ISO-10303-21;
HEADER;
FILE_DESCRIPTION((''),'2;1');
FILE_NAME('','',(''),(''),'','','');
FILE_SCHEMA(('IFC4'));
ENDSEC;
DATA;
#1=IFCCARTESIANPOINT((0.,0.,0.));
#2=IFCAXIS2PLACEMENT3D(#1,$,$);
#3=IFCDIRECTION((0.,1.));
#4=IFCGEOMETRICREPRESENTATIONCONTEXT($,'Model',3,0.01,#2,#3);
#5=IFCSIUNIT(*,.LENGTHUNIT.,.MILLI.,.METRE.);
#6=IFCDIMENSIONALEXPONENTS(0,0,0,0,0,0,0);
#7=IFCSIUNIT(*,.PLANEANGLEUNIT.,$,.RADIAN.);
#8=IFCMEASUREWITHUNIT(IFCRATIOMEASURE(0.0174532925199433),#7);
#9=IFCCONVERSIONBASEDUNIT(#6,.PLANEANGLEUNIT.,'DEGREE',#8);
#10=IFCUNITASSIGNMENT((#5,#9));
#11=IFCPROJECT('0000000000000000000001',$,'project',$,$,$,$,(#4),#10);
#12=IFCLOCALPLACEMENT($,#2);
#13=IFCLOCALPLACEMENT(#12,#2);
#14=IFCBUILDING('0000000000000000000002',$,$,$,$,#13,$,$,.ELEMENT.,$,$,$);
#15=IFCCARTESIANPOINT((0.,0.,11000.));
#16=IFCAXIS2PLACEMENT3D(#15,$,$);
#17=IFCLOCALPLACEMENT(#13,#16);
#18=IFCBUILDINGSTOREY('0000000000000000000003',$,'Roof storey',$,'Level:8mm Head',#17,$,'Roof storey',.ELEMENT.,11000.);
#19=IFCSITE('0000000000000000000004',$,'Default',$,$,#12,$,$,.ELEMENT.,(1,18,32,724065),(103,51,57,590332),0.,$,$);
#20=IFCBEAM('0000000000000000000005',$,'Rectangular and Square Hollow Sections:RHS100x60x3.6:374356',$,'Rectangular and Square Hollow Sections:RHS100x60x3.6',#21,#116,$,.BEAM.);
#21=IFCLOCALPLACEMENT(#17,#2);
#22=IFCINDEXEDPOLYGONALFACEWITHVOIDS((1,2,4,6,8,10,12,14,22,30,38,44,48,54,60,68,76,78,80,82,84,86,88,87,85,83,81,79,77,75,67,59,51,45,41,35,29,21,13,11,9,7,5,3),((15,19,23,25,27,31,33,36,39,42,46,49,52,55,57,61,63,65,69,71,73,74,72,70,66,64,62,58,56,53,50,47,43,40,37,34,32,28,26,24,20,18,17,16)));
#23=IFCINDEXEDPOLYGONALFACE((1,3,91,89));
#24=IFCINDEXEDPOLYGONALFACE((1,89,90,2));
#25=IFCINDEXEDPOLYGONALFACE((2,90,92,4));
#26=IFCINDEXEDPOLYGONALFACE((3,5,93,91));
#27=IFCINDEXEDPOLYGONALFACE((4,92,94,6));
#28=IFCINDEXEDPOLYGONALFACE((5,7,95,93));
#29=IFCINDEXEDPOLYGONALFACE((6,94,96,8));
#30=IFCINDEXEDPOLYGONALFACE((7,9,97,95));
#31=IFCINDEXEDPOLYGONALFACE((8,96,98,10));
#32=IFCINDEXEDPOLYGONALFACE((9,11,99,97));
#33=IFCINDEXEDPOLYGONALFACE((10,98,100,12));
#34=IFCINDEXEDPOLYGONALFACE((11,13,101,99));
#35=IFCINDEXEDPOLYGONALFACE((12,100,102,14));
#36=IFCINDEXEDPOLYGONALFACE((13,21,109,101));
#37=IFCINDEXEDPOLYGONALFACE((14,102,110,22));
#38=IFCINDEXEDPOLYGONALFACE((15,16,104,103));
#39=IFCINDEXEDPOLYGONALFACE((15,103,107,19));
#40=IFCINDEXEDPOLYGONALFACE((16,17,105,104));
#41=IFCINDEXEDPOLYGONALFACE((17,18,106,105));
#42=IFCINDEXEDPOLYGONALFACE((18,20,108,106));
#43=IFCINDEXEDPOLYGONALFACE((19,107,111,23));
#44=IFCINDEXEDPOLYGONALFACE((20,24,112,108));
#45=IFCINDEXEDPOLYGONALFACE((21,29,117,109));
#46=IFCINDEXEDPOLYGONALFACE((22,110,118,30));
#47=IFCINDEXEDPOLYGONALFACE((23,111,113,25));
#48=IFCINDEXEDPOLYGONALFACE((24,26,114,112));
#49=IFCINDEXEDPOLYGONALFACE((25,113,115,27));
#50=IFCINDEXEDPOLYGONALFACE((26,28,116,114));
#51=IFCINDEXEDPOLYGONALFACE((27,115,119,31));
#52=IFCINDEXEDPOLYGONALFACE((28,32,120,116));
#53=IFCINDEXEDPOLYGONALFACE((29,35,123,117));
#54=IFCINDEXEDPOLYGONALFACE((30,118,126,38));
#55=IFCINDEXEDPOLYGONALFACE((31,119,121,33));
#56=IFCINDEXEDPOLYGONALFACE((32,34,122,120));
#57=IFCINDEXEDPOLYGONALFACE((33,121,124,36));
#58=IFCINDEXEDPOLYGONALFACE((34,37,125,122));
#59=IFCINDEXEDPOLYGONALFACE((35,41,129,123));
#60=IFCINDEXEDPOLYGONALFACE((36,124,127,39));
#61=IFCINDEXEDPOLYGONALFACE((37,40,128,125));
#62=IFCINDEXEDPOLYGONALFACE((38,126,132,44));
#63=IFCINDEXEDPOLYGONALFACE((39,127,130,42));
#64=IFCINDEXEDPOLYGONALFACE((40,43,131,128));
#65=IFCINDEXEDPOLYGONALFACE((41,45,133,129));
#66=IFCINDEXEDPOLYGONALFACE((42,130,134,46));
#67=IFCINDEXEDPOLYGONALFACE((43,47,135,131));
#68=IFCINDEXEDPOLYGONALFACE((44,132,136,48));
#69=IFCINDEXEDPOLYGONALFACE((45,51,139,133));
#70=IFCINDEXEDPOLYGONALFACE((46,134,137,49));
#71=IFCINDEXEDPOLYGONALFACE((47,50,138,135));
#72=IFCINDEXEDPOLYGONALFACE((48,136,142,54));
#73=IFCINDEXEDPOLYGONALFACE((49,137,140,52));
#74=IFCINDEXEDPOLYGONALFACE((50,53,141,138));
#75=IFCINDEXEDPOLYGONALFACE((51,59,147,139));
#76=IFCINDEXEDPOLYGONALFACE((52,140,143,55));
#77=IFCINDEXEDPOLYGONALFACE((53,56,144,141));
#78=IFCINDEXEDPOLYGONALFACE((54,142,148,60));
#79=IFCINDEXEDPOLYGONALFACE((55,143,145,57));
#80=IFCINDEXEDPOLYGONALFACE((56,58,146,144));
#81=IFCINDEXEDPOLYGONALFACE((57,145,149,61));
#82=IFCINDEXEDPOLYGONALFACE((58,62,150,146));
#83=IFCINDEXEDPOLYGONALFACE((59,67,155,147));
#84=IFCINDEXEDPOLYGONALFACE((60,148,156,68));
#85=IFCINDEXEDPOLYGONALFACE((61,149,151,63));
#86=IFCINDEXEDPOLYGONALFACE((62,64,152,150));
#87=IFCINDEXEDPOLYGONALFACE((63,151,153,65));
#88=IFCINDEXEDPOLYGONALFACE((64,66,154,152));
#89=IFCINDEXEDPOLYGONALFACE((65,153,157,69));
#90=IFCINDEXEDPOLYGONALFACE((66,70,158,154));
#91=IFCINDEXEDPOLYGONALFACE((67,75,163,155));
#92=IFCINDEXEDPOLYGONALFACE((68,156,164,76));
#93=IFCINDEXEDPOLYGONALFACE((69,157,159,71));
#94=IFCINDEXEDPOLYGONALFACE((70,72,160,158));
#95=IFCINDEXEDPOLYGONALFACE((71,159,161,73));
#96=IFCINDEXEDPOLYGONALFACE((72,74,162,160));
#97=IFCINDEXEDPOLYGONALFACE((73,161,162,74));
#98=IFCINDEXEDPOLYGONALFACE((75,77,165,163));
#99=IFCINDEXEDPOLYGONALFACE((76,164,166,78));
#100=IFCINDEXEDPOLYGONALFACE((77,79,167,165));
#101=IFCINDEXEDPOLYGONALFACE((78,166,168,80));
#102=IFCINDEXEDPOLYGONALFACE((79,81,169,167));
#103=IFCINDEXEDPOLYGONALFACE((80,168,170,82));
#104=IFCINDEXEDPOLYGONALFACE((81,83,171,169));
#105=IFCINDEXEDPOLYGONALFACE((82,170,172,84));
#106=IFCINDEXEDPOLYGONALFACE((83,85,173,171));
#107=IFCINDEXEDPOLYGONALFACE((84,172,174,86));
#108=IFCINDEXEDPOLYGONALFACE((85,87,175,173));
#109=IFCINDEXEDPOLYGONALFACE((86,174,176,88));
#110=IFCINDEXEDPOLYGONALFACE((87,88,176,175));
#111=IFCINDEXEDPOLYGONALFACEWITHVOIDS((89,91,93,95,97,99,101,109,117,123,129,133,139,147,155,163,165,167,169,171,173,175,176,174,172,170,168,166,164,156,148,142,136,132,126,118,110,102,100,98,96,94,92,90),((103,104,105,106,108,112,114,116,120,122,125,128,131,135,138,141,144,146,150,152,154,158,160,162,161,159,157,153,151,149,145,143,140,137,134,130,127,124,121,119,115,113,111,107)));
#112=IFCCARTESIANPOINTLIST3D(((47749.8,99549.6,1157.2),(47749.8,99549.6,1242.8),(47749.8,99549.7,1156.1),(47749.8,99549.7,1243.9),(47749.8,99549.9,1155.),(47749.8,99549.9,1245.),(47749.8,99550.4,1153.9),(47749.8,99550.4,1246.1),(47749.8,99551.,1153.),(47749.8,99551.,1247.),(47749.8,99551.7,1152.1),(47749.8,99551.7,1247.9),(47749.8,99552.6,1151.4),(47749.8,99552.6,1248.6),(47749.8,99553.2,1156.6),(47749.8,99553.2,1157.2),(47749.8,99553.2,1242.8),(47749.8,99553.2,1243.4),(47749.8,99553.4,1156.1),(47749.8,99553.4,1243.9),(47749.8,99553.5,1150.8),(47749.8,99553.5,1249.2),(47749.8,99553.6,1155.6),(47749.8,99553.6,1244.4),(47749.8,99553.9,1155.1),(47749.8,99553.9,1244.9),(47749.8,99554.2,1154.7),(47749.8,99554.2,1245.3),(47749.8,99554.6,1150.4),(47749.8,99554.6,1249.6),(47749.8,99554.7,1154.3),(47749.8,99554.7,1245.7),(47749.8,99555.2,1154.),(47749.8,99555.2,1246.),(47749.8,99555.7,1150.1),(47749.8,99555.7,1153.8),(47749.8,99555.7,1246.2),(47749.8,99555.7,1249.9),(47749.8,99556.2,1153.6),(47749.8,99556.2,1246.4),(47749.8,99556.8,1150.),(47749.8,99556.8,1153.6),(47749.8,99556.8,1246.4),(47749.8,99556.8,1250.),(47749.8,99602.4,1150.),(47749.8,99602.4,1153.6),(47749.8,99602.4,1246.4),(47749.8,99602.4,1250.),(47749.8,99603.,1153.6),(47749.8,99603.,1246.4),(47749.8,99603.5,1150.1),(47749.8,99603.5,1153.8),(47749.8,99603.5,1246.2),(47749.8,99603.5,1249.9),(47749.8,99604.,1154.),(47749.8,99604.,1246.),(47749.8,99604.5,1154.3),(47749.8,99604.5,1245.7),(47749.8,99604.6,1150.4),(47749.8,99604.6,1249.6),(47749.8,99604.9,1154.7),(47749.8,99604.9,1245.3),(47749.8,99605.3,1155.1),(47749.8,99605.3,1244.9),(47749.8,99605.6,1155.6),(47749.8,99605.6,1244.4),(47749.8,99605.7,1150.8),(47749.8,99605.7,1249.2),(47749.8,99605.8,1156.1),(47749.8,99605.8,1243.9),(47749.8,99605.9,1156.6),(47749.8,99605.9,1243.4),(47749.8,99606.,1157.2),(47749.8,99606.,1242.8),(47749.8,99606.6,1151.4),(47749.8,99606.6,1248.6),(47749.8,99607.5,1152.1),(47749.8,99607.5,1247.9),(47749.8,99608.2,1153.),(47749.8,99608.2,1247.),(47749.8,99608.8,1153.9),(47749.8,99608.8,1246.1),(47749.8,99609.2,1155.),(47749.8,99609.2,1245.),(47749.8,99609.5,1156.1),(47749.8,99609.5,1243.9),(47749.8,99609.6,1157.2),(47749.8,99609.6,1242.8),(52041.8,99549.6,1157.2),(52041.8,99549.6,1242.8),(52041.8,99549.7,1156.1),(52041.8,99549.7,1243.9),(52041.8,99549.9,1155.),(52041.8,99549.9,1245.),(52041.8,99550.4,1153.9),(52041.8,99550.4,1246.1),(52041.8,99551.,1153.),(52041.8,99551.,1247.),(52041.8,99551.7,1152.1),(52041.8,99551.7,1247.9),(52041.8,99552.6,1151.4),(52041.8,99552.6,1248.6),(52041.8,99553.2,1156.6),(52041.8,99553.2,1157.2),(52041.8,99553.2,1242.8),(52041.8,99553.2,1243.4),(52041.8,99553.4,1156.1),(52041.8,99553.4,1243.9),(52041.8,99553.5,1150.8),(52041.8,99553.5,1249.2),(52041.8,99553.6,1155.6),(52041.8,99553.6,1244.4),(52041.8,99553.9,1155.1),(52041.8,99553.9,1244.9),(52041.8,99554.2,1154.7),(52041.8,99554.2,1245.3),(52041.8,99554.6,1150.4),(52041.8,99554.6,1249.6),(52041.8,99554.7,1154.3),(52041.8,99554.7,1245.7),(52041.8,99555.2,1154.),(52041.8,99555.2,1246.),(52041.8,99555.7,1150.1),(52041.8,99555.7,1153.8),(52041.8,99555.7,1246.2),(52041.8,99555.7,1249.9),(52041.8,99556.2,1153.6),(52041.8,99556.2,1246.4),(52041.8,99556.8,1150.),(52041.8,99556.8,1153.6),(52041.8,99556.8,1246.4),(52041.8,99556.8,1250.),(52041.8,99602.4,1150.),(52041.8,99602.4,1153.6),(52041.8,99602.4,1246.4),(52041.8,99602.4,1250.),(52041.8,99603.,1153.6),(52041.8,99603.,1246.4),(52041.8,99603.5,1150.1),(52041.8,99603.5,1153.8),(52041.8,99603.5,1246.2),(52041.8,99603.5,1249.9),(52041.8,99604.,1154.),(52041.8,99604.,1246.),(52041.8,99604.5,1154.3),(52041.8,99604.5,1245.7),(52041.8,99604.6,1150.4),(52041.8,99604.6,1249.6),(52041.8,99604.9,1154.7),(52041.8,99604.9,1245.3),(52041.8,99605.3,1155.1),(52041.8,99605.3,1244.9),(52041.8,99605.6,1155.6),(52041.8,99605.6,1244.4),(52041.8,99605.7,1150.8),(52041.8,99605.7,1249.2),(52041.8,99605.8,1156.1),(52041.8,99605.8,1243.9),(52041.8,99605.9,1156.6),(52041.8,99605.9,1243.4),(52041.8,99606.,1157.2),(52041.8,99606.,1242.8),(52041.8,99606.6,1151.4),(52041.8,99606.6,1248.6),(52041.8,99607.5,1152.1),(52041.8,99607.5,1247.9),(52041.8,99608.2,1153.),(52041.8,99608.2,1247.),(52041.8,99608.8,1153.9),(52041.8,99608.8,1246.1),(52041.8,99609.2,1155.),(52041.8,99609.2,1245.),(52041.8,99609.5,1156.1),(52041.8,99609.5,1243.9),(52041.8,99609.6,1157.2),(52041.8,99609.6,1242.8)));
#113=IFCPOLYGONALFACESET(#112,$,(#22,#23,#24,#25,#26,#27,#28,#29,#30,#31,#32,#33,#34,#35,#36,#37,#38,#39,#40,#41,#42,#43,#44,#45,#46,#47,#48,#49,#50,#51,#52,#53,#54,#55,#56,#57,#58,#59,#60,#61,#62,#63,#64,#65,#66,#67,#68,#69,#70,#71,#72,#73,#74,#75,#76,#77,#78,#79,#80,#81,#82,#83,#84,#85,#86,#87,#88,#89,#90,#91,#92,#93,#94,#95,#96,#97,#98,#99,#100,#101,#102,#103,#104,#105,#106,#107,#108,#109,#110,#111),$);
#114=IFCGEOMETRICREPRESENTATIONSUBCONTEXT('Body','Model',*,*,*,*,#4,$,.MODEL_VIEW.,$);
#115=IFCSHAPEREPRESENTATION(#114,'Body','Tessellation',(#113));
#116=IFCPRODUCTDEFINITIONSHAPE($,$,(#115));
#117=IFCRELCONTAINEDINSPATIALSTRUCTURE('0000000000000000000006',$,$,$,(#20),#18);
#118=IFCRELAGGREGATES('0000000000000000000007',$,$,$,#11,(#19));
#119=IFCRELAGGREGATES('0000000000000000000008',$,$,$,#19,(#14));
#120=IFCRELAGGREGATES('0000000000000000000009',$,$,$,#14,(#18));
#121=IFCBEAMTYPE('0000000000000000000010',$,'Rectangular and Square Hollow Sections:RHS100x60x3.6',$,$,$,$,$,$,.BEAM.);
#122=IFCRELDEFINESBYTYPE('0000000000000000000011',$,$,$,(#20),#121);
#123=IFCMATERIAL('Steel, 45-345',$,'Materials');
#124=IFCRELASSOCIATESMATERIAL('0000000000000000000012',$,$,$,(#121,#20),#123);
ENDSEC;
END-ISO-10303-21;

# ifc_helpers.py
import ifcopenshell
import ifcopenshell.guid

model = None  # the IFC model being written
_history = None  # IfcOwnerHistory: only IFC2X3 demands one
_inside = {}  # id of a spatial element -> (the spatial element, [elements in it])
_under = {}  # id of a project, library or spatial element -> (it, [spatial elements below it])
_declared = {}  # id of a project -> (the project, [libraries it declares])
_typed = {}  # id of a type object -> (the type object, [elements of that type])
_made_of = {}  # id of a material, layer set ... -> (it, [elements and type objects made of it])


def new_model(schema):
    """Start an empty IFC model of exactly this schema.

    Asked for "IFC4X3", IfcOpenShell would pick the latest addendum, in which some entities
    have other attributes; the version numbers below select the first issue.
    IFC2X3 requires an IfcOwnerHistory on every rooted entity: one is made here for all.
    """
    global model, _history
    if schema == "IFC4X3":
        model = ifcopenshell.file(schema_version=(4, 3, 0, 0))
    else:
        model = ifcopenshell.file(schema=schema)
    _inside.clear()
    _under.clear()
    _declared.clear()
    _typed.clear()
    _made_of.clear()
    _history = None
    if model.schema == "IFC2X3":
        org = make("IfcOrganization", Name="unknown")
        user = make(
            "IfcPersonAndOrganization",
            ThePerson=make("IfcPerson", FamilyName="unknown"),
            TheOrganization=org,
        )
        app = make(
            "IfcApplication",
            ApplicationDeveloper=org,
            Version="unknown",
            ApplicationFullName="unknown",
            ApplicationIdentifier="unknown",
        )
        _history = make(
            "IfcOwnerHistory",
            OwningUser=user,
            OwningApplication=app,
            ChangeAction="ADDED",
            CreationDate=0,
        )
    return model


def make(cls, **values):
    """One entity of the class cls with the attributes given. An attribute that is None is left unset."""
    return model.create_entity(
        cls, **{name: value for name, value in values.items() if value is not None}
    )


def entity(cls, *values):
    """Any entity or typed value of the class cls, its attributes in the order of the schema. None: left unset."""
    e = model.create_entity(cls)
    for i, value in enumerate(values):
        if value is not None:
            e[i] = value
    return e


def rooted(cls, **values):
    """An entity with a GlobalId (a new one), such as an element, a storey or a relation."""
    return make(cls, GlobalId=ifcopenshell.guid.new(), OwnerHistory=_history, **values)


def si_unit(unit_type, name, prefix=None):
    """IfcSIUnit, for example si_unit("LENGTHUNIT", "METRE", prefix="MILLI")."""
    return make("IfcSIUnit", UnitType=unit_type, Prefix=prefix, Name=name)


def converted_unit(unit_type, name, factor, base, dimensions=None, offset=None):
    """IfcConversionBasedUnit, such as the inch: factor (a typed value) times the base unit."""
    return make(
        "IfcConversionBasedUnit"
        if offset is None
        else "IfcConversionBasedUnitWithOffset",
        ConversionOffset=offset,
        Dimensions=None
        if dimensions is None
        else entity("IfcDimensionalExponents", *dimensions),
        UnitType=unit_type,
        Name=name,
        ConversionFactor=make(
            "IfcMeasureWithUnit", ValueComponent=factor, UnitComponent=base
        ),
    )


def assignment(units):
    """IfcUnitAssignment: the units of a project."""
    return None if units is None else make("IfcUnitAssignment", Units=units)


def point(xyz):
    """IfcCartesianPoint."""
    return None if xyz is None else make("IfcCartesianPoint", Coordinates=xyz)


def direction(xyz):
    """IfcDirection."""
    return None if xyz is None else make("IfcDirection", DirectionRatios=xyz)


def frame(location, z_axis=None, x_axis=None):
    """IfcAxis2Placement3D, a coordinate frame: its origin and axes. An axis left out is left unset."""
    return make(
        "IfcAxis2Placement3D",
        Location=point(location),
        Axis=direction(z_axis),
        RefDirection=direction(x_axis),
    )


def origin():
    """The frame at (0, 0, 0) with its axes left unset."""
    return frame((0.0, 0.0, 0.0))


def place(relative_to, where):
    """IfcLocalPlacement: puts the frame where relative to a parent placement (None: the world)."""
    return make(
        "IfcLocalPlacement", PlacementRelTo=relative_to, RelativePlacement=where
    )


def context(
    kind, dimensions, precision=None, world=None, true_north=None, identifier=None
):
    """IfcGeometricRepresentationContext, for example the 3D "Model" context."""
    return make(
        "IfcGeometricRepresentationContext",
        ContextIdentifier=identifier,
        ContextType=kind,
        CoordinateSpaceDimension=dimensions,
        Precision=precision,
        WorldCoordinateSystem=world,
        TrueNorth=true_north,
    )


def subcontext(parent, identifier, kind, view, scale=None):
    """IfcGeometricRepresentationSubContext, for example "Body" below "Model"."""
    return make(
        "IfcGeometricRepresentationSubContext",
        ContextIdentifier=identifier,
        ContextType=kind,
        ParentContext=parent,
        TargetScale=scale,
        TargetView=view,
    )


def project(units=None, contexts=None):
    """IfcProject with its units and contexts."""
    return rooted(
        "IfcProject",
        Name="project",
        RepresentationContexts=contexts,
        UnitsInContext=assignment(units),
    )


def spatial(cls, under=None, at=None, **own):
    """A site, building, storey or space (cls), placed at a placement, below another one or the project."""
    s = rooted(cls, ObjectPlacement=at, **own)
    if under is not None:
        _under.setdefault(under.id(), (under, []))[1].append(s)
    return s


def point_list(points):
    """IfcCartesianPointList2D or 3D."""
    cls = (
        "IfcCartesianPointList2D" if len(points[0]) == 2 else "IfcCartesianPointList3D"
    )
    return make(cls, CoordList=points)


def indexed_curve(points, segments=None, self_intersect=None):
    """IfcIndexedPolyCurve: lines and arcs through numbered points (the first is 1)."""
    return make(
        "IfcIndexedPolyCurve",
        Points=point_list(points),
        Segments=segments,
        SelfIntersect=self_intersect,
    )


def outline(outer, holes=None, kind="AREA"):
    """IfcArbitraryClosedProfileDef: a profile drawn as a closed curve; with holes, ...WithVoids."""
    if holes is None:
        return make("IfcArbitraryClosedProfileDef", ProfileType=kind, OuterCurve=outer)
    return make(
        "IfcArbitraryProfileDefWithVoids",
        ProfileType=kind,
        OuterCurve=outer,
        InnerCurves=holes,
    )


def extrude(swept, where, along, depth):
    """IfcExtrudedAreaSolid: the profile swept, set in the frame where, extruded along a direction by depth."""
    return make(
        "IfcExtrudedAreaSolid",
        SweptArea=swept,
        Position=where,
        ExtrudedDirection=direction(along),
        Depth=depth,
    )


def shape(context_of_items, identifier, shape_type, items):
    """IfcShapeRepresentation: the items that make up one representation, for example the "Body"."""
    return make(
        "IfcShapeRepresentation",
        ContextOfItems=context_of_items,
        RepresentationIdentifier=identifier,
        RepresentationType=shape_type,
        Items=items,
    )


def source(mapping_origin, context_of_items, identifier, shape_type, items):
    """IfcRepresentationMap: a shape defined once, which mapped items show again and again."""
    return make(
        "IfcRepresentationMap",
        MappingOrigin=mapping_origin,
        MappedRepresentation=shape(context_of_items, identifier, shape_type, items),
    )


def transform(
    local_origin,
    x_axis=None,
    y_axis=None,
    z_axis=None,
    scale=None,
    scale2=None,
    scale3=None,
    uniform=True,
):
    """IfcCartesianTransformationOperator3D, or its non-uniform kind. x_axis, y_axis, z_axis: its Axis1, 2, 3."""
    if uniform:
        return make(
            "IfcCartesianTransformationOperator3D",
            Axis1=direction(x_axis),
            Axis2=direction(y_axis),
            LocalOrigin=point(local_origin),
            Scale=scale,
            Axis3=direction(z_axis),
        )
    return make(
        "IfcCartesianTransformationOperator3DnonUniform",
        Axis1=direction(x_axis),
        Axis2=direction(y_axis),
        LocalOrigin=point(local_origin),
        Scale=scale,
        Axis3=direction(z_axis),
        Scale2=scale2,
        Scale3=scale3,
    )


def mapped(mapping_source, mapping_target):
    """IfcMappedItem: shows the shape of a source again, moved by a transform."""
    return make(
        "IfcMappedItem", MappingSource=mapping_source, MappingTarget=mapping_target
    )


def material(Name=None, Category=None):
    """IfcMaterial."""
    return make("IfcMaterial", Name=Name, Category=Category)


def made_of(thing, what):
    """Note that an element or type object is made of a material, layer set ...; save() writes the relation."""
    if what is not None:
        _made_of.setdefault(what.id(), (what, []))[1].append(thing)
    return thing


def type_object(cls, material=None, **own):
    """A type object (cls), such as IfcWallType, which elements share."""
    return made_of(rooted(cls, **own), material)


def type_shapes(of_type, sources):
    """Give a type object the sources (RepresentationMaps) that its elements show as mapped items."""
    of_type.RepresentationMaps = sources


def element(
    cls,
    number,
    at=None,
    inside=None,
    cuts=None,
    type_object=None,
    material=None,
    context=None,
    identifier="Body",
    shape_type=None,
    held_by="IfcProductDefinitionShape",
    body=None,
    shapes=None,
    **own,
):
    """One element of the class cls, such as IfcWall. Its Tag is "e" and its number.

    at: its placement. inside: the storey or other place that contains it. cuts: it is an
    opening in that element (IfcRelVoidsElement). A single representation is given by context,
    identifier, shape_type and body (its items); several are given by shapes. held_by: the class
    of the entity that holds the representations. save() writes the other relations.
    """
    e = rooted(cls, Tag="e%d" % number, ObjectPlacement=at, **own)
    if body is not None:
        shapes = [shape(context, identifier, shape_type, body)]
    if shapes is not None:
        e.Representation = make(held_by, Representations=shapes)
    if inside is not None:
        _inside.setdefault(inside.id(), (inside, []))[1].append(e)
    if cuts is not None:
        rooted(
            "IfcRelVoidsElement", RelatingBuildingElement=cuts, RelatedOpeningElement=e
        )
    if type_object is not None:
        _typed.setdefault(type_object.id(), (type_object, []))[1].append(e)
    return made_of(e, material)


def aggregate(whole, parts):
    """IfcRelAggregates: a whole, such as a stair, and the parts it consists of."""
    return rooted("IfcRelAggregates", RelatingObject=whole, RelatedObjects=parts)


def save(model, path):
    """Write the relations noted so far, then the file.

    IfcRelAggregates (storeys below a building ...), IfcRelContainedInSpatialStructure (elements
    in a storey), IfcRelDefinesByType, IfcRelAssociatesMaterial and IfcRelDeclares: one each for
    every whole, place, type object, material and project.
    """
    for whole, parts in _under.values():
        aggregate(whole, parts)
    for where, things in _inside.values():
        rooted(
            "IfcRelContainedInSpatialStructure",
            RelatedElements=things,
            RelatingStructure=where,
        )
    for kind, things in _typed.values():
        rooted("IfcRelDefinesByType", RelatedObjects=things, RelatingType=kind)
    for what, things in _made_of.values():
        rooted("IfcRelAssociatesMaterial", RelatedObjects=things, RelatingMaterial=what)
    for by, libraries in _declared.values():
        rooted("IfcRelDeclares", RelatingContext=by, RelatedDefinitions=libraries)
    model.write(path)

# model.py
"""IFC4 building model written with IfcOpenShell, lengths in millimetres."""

from ifc_helpers import new_model, entity, si_unit, converted_unit, direction, frame, origin, place, context, subcontext, project, spatial, indexed_curve, outline, extrude, source, transform, mapped, material, type_object, type_shapes, element, save


model = new_model("IFC4")

# Units and contexts
model_context = context("Model", 3, precision=0.01, world=origin(), true_north=direction((0.0, 1.0)))
body_context = subcontext(model_context, "Body", "Model", "MODEL_VIEW")
ifc_project = project(units=[si_unit("LENGTHUNIT", "METRE", prefix="MILLI"), converted_unit("PLANEANGLEUNIT", "DEGREE", entity("IfcRatioMeasure", 0.0174532925199433), si_unit("PLANEANGLEUNIT", "RADIAN"), dimensions=[0, 0, 0, 0, 0, 0, 0])], contexts=[model_context])

# Site, building, storey
site_placement = place(None, origin())
site = spatial("IfcSite", under=ifc_project, at=site_placement, Name="Default", CompositionType="ELEMENT", RefLatitude=(1, 18, 32, 724065), RefLongitude=(103, 51, 57, 590332), RefElevation=0.0)
building_placement = place(site_placement, origin())
building = spatial("IfcBuilding", under=site, at=building_placement, CompositionType="ELEMENT")
storey_placement = place(building_placement, frame((0.0, 0.0, 11000.0)))
storey = spatial("IfcBuildingStorey", under=building, at=storey_placement, Name="Roof storey", ObjectType="Level:8mm Head", LongName="Roof storey", CompositionType="ELEMENT", Elevation=11000.0)

# Shared definitions
ifc_material = material(Name="Steel, 45-345", Category="Materials")

# Beam
beam_type_1 = type_object("IfcBeamType", Name="Rectangular and Square Hollow Sections:RHS100x60x3.6", PredefinedType="BEAM", material=ifc_material)
shared_shape_1 = source(origin(), body_context, "Body", "SweptSolid", [
    extrude(outline(indexed_curve([(-30.0, -42.8), (-29.9, -43.9), (-29.6, -45.0), (-29.2, -46.1), (-28.6, -47.0), (-27.9, -47.9), (-27.0, -48.6), (-26.1, -49.2), (-25.0, -49.6), (-23.9, -49.9), (-22.8, -50.0), (22.8, -50.0), (23.9, -49.9), (25.0, -49.6), (26.1, -49.2), (27.0, -48.6), (27.9, -47.9), (28.6, -47.0), (29.2, -46.1), (29.6, -45.0), (29.9, -43.9), (30.0, -42.8), (30.0, 42.8), (29.9, 43.9), (29.6, 45.0), (29.2, 46.1), (28.6, 47.0), (27.9, 47.9), (27.0, 48.6), (26.1, 49.2), (25.0, 49.6), (23.9, 49.9), (22.8, 50.0), (-22.8, 50.0), (-23.9, 49.9), (-25.0, 49.6), (-26.1, 49.2), (-27.0, 48.6), (-27.9, 47.9), (-28.6, 47.0), (-29.2, 46.1), (-29.6, 45.0), (-29.9, 43.9), (-30.0, 42.8), (-30.0, -42.8)], self_intersect=False), holes=[indexed_curve([(22.8, -46.4), (-22.8, -46.4), (-23.4, -46.4), (-23.9, -46.2), (-24.4, -46.0), (-24.9, -45.7), (-25.3, -45.3), (-25.7, -44.9), (-26.0, -44.4), (-26.2, -43.9), (-26.4, -43.4), (-26.4, -42.8), (-26.4, 42.8), (-26.4, 43.4), (-26.2, 43.9), (-26.0, 44.4), (-25.7, 44.9), (-25.3, 45.3), (-24.9, 45.7), (-24.4, 46.0), (-23.9, 46.2), (-23.4, 46.4), (-22.8, 46.4), (22.8, 46.4), (23.4, 46.4), (23.9, 46.2), (24.4, 46.0), (24.9, 45.7), (25.3, 45.3), (25.7, 44.9), (26.0, 44.4), (26.2, 43.9), (26.4, 43.4), (26.4, 42.8), (26.4, -42.8), (26.4, -43.4), (26.2, -43.9), (26.0, -44.4), (25.7, -44.9), (25.3, -45.3), (24.9, -45.7), (24.4, -46.0), (23.9, -46.2), (23.4, -46.4), (22.8, -46.4)], self_intersect=False)]), frame((-2139.5, 0.0, 0.0), z_axis=(1.0, 0.0, 0.0), x_axis=(0.0, -1.0, 0.0)), (0.0, 0.0, 1.0), 4292.0),
])
type_shapes(beam_type_1, [shared_shape_1])
for number, where, name in (
    (1, (49889.3, 99579.6, 1200.0), "Rectangular and Square Hollow Sections:RHS100x60x3.6:374356"),
):
    element("IfcBeam", number, at=place(storey_placement, frame(where)), inside=storey, type_object=beam_type_1, material=ifc_material, Name=name, ObjectType="Rectangular and Square Hollow Sections:RHS100x60x3.6", PredefinedType="BEAM", context=body_context, shape_type="MappedRepresentation", body=[
        mapped(shared_shape_1, transform((0.0, 0.0, 0.0), scale=1.0)),
    ])

save(model, "model.ifc")
